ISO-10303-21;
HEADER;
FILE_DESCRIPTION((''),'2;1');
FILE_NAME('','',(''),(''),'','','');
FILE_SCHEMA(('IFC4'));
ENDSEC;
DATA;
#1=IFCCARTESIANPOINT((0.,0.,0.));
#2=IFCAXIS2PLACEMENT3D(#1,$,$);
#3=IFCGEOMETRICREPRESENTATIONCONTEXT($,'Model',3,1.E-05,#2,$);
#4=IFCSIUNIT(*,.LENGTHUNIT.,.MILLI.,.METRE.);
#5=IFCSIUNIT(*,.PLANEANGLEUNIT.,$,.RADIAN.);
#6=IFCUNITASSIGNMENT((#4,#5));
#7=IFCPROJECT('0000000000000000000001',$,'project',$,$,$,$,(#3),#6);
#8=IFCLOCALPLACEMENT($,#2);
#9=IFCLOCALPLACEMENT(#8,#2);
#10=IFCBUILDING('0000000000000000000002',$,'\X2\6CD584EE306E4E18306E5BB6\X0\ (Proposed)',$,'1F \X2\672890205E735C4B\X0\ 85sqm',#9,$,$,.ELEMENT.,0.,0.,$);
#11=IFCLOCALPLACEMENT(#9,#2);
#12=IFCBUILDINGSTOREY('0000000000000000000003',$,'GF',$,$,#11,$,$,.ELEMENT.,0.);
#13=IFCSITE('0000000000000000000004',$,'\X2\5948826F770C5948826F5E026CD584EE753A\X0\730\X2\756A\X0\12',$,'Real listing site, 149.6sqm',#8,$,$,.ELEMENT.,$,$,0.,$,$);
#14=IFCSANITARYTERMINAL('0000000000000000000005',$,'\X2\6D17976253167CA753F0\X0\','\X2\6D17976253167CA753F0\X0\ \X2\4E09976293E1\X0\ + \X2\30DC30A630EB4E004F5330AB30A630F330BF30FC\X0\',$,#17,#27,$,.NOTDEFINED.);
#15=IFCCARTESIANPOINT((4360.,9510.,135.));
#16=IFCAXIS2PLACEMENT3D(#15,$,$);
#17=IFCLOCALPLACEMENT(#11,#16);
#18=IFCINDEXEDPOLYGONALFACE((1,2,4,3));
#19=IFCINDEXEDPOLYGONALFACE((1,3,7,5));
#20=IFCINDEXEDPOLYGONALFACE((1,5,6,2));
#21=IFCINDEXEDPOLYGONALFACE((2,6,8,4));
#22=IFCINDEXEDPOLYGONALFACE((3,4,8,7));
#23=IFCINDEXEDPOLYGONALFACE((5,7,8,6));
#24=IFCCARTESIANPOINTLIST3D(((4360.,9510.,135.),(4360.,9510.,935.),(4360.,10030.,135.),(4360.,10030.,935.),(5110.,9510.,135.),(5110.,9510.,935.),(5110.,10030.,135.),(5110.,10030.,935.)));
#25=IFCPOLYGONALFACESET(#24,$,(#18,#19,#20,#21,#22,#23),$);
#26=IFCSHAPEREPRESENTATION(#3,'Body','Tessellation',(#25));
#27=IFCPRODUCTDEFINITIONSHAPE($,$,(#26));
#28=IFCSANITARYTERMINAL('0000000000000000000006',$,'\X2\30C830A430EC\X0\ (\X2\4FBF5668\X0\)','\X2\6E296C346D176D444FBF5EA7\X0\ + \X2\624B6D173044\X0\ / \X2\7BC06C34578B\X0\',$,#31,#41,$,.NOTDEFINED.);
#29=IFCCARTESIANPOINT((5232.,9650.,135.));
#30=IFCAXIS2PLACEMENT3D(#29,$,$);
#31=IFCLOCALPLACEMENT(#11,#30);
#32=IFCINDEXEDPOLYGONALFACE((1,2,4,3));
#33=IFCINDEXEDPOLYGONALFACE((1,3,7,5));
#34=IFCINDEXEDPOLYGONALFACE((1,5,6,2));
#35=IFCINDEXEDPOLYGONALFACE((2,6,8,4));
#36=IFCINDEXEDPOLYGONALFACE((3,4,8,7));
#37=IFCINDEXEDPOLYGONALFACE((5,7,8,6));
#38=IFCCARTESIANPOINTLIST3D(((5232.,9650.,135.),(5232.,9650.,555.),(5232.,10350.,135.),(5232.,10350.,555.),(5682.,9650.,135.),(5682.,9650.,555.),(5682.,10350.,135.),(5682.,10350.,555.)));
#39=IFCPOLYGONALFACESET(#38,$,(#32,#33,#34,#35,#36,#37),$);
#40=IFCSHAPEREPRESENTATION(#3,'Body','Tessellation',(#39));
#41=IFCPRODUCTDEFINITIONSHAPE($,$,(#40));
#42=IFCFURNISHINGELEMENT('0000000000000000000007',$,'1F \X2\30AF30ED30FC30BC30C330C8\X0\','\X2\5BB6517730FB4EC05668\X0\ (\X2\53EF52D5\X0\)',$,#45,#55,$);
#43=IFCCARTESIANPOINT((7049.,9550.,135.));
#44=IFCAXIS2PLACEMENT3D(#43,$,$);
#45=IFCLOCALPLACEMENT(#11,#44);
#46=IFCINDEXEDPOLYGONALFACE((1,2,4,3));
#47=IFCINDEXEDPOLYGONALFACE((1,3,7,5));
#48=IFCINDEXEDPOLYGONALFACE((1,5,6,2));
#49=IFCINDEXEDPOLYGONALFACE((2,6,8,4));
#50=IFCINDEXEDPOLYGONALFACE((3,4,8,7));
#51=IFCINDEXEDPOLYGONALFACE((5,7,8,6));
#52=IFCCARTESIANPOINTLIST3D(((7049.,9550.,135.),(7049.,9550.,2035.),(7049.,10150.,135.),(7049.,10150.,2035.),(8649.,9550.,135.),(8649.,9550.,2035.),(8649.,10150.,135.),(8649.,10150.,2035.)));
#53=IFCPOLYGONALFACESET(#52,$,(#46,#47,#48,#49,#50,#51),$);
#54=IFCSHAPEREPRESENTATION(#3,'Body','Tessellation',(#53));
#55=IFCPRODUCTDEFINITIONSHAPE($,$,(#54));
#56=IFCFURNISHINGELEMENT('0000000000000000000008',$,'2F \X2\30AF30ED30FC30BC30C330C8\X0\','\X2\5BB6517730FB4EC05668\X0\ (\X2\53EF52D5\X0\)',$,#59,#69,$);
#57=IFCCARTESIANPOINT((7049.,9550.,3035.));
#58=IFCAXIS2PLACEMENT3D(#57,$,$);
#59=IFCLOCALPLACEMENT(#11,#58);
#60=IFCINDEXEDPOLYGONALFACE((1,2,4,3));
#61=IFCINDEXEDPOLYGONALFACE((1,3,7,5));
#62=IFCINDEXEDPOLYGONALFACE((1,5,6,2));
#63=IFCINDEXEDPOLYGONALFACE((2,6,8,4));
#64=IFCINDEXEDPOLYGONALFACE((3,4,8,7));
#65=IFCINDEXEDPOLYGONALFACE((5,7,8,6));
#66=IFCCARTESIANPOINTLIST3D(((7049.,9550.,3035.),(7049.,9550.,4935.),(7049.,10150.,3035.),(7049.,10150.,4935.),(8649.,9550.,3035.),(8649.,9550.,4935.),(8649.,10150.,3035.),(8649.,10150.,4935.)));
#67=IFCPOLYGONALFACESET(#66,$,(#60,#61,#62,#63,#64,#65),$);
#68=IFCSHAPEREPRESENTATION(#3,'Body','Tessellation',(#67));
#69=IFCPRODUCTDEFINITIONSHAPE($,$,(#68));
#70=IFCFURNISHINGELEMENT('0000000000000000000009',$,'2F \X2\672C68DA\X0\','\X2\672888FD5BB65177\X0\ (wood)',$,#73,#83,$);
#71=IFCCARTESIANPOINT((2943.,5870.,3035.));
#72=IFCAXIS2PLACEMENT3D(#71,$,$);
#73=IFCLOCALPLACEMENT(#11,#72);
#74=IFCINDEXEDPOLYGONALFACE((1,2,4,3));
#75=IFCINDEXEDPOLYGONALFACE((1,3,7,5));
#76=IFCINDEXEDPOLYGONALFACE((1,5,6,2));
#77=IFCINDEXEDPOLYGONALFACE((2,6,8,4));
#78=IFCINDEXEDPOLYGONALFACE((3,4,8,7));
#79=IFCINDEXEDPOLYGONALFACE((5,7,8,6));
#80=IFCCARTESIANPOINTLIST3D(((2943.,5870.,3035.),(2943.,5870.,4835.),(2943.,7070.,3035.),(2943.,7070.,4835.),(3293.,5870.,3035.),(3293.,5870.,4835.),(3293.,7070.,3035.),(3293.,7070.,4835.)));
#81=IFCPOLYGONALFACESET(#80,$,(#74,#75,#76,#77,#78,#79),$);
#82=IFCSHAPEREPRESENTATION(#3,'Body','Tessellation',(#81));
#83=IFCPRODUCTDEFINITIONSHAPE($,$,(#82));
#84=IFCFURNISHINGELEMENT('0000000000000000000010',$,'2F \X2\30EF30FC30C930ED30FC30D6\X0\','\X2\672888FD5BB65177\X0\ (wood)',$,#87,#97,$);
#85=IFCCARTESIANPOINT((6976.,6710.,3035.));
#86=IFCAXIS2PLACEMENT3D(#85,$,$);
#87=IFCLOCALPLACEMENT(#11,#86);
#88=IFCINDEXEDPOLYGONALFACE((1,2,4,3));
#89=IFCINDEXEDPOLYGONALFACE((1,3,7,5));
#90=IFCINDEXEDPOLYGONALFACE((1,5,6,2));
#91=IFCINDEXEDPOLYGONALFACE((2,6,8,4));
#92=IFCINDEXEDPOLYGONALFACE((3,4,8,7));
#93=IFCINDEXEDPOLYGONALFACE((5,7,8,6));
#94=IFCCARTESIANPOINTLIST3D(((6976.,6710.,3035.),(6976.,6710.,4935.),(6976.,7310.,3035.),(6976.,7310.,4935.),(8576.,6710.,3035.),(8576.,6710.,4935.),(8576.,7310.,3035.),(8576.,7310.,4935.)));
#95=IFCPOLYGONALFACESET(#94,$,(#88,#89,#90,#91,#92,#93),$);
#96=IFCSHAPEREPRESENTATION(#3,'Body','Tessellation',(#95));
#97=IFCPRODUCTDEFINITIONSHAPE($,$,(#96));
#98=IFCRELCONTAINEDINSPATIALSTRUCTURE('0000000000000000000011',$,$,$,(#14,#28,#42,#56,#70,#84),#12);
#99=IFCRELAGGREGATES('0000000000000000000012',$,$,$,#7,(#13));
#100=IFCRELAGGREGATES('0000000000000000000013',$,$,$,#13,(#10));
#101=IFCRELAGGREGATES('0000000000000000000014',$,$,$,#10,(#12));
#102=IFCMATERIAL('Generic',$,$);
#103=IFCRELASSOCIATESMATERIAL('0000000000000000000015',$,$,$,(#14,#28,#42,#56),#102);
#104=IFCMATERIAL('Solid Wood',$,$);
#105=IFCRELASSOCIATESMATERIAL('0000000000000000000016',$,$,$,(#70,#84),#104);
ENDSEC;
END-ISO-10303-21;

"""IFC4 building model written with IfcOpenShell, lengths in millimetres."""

from ifc_helpers import new_model, si_unit, frame, frame_2d, origin, place, context, project, spatial, rectangle, extrude, material, element, save


model = new_model("IFC4")

# Units and contexts
model_context = context("Model", 3, precision=1e-05, world=origin())
ifc_project = project(units=[si_unit("LENGTHUNIT", "METRE", prefix="MILLI"), si_unit("PLANEANGLEUNIT", "RADIAN")], contexts=[model_context])

# Site, building, storey
site_placement = place(None, origin())
site = spatial("IfcSite", under=ifc_project, at=site_placement, Name="奈良県奈良市法蓮町730番12", ObjectType="Real listing site, 149.6sqm", CompositionType="ELEMENT", RefElevation=0.0)
building_placement = place(site_placement, origin())
building = spatial("IfcBuilding", under=site, at=building_placement, Name="法蓮の丘の家 (Proposed)", ObjectType="1F 木造平屋 85sqm", CompositionType="ELEMENT", ElevationOfRefHeight=0.0, ElevationOfTerrain=0.0)
storey_placement = place(building_placement, origin())
storey = spatial("IfcBuildingStorey", under=building, at=storey_placement, Name="GF", CompositionType="ELEMENT", Elevation=0.0)

# Shared definitions
ifc_material_1 = material(Name="Solid Wood")

# Shared definitions
ifc_material_2 = material(Name="Generic")

# Sanitary terminals
sanitary_terminal_1_placement = place(storey_placement, frame((4360.0, 9510.0, 135.0)))
element("IfcSanitaryTerminal", 1, at=sanitary_terminal_1_placement, inside=storey, material=ifc_material_2, Name="洗面化粧台", Description="洗面化粧台 三面鏡 + ボウル一体カウンター", PredefinedType="NOTDEFINED", context=model_context, shape_type="SweptSolid", body=[
    extrude(rectangle(XDim=750.0, YDim=520.0, at=frame_2d((375.0, 260.0))), frame((4360.0, 9510.0, 135.0)), (0.0, 0.0, 1.0), 800.0),
])
sanitary_terminal_2_placement = place(storey_placement, frame((5232.0, 9650.0, 135.0)))
element("IfcSanitaryTerminal", 2, at=sanitary_terminal_2_placement, inside=storey, material=ifc_material_2, Name="トイレ (便器)", Description="温水洗浄便座 + 手洗い / 節水型", PredefinedType="NOTDEFINED", context=model_context, shape_type="SweptSolid", body=[
    extrude(rectangle(XDim=450.0, YDim=700.0, at=frame_2d((225.0, 350.0))), frame((5232.0, 9650.0, 135.0)), (0.0, 0.0, 1.0), 420.0),
])

# Furnishing elements
furnishing_1_placement = place(storey_placement, frame((7049.0, 9550.0, 135.0)))
element("IfcFurnishingElement", 3, at=furnishing_1_placement, inside=storey, material=ifc_material_2, Name="1F クローゼット", Description="家具・什器 (可動)", context=model_context, shape_type="SweptSolid", body=[
    extrude(rectangle(XDim=1600.0, YDim=600.0, at=frame_2d((800.0, 300.0))), frame((7049.0, 9550.0, 135.0)), (0.0, 0.0, 1.0), 1900.0),
])
furnishing_2_placement = place(storey_placement, frame((7049.0, 9550.0, 3035.0)))
element("IfcFurnishingElement", 4, at=furnishing_2_placement, inside=storey, material=ifc_material_2, Name="2F クローゼット", Description="家具・什器 (可動)", context=model_context, shape_type="SweptSolid", body=[
    extrude(rectangle(XDim=1600.0, YDim=600.0, at=frame_2d((800.0, 300.0))), frame((7049.0, 9550.0, 3035.0)), (0.0, 0.0, 1.0), 1900.0),
])
furnishing_3_placement = place(storey_placement, frame((2943.0, 5870.0, 3035.0)))
element("IfcFurnishingElement", 5, at=furnishing_3_placement, inside=storey, material=ifc_material_1, Name="2F 本棚", Description="木製家具 (wood)", context=model_context, shape_type="SweptSolid", body=[
    extrude(rectangle(XDim=350.0, YDim=1200.0, at=frame_2d((175.0, 600.0))), frame((2943.0, 5870.0, 3035.0)), (0.0, 0.0, 1.0), 1800.0),
])
furnishing_4_placement = place(storey_placement, frame((6976.0, 6710.0, 3035.0)))
element("IfcFurnishingElement", 6, at=furnishing_4_placement, inside=storey, material=ifc_material_1, Name="2F ワードローブ", Description="木製家具 (wood)", context=model_context, shape_type="SweptSolid", body=[
    extrude(rectangle(XDim=1600.0, YDim=600.0, at=frame_2d((800.0, 300.0))), frame((6976.0, 6710.0, 3035.0)), (0.0, 0.0, 1.0), 1900.0),
])

save(model, "model.ifc")
